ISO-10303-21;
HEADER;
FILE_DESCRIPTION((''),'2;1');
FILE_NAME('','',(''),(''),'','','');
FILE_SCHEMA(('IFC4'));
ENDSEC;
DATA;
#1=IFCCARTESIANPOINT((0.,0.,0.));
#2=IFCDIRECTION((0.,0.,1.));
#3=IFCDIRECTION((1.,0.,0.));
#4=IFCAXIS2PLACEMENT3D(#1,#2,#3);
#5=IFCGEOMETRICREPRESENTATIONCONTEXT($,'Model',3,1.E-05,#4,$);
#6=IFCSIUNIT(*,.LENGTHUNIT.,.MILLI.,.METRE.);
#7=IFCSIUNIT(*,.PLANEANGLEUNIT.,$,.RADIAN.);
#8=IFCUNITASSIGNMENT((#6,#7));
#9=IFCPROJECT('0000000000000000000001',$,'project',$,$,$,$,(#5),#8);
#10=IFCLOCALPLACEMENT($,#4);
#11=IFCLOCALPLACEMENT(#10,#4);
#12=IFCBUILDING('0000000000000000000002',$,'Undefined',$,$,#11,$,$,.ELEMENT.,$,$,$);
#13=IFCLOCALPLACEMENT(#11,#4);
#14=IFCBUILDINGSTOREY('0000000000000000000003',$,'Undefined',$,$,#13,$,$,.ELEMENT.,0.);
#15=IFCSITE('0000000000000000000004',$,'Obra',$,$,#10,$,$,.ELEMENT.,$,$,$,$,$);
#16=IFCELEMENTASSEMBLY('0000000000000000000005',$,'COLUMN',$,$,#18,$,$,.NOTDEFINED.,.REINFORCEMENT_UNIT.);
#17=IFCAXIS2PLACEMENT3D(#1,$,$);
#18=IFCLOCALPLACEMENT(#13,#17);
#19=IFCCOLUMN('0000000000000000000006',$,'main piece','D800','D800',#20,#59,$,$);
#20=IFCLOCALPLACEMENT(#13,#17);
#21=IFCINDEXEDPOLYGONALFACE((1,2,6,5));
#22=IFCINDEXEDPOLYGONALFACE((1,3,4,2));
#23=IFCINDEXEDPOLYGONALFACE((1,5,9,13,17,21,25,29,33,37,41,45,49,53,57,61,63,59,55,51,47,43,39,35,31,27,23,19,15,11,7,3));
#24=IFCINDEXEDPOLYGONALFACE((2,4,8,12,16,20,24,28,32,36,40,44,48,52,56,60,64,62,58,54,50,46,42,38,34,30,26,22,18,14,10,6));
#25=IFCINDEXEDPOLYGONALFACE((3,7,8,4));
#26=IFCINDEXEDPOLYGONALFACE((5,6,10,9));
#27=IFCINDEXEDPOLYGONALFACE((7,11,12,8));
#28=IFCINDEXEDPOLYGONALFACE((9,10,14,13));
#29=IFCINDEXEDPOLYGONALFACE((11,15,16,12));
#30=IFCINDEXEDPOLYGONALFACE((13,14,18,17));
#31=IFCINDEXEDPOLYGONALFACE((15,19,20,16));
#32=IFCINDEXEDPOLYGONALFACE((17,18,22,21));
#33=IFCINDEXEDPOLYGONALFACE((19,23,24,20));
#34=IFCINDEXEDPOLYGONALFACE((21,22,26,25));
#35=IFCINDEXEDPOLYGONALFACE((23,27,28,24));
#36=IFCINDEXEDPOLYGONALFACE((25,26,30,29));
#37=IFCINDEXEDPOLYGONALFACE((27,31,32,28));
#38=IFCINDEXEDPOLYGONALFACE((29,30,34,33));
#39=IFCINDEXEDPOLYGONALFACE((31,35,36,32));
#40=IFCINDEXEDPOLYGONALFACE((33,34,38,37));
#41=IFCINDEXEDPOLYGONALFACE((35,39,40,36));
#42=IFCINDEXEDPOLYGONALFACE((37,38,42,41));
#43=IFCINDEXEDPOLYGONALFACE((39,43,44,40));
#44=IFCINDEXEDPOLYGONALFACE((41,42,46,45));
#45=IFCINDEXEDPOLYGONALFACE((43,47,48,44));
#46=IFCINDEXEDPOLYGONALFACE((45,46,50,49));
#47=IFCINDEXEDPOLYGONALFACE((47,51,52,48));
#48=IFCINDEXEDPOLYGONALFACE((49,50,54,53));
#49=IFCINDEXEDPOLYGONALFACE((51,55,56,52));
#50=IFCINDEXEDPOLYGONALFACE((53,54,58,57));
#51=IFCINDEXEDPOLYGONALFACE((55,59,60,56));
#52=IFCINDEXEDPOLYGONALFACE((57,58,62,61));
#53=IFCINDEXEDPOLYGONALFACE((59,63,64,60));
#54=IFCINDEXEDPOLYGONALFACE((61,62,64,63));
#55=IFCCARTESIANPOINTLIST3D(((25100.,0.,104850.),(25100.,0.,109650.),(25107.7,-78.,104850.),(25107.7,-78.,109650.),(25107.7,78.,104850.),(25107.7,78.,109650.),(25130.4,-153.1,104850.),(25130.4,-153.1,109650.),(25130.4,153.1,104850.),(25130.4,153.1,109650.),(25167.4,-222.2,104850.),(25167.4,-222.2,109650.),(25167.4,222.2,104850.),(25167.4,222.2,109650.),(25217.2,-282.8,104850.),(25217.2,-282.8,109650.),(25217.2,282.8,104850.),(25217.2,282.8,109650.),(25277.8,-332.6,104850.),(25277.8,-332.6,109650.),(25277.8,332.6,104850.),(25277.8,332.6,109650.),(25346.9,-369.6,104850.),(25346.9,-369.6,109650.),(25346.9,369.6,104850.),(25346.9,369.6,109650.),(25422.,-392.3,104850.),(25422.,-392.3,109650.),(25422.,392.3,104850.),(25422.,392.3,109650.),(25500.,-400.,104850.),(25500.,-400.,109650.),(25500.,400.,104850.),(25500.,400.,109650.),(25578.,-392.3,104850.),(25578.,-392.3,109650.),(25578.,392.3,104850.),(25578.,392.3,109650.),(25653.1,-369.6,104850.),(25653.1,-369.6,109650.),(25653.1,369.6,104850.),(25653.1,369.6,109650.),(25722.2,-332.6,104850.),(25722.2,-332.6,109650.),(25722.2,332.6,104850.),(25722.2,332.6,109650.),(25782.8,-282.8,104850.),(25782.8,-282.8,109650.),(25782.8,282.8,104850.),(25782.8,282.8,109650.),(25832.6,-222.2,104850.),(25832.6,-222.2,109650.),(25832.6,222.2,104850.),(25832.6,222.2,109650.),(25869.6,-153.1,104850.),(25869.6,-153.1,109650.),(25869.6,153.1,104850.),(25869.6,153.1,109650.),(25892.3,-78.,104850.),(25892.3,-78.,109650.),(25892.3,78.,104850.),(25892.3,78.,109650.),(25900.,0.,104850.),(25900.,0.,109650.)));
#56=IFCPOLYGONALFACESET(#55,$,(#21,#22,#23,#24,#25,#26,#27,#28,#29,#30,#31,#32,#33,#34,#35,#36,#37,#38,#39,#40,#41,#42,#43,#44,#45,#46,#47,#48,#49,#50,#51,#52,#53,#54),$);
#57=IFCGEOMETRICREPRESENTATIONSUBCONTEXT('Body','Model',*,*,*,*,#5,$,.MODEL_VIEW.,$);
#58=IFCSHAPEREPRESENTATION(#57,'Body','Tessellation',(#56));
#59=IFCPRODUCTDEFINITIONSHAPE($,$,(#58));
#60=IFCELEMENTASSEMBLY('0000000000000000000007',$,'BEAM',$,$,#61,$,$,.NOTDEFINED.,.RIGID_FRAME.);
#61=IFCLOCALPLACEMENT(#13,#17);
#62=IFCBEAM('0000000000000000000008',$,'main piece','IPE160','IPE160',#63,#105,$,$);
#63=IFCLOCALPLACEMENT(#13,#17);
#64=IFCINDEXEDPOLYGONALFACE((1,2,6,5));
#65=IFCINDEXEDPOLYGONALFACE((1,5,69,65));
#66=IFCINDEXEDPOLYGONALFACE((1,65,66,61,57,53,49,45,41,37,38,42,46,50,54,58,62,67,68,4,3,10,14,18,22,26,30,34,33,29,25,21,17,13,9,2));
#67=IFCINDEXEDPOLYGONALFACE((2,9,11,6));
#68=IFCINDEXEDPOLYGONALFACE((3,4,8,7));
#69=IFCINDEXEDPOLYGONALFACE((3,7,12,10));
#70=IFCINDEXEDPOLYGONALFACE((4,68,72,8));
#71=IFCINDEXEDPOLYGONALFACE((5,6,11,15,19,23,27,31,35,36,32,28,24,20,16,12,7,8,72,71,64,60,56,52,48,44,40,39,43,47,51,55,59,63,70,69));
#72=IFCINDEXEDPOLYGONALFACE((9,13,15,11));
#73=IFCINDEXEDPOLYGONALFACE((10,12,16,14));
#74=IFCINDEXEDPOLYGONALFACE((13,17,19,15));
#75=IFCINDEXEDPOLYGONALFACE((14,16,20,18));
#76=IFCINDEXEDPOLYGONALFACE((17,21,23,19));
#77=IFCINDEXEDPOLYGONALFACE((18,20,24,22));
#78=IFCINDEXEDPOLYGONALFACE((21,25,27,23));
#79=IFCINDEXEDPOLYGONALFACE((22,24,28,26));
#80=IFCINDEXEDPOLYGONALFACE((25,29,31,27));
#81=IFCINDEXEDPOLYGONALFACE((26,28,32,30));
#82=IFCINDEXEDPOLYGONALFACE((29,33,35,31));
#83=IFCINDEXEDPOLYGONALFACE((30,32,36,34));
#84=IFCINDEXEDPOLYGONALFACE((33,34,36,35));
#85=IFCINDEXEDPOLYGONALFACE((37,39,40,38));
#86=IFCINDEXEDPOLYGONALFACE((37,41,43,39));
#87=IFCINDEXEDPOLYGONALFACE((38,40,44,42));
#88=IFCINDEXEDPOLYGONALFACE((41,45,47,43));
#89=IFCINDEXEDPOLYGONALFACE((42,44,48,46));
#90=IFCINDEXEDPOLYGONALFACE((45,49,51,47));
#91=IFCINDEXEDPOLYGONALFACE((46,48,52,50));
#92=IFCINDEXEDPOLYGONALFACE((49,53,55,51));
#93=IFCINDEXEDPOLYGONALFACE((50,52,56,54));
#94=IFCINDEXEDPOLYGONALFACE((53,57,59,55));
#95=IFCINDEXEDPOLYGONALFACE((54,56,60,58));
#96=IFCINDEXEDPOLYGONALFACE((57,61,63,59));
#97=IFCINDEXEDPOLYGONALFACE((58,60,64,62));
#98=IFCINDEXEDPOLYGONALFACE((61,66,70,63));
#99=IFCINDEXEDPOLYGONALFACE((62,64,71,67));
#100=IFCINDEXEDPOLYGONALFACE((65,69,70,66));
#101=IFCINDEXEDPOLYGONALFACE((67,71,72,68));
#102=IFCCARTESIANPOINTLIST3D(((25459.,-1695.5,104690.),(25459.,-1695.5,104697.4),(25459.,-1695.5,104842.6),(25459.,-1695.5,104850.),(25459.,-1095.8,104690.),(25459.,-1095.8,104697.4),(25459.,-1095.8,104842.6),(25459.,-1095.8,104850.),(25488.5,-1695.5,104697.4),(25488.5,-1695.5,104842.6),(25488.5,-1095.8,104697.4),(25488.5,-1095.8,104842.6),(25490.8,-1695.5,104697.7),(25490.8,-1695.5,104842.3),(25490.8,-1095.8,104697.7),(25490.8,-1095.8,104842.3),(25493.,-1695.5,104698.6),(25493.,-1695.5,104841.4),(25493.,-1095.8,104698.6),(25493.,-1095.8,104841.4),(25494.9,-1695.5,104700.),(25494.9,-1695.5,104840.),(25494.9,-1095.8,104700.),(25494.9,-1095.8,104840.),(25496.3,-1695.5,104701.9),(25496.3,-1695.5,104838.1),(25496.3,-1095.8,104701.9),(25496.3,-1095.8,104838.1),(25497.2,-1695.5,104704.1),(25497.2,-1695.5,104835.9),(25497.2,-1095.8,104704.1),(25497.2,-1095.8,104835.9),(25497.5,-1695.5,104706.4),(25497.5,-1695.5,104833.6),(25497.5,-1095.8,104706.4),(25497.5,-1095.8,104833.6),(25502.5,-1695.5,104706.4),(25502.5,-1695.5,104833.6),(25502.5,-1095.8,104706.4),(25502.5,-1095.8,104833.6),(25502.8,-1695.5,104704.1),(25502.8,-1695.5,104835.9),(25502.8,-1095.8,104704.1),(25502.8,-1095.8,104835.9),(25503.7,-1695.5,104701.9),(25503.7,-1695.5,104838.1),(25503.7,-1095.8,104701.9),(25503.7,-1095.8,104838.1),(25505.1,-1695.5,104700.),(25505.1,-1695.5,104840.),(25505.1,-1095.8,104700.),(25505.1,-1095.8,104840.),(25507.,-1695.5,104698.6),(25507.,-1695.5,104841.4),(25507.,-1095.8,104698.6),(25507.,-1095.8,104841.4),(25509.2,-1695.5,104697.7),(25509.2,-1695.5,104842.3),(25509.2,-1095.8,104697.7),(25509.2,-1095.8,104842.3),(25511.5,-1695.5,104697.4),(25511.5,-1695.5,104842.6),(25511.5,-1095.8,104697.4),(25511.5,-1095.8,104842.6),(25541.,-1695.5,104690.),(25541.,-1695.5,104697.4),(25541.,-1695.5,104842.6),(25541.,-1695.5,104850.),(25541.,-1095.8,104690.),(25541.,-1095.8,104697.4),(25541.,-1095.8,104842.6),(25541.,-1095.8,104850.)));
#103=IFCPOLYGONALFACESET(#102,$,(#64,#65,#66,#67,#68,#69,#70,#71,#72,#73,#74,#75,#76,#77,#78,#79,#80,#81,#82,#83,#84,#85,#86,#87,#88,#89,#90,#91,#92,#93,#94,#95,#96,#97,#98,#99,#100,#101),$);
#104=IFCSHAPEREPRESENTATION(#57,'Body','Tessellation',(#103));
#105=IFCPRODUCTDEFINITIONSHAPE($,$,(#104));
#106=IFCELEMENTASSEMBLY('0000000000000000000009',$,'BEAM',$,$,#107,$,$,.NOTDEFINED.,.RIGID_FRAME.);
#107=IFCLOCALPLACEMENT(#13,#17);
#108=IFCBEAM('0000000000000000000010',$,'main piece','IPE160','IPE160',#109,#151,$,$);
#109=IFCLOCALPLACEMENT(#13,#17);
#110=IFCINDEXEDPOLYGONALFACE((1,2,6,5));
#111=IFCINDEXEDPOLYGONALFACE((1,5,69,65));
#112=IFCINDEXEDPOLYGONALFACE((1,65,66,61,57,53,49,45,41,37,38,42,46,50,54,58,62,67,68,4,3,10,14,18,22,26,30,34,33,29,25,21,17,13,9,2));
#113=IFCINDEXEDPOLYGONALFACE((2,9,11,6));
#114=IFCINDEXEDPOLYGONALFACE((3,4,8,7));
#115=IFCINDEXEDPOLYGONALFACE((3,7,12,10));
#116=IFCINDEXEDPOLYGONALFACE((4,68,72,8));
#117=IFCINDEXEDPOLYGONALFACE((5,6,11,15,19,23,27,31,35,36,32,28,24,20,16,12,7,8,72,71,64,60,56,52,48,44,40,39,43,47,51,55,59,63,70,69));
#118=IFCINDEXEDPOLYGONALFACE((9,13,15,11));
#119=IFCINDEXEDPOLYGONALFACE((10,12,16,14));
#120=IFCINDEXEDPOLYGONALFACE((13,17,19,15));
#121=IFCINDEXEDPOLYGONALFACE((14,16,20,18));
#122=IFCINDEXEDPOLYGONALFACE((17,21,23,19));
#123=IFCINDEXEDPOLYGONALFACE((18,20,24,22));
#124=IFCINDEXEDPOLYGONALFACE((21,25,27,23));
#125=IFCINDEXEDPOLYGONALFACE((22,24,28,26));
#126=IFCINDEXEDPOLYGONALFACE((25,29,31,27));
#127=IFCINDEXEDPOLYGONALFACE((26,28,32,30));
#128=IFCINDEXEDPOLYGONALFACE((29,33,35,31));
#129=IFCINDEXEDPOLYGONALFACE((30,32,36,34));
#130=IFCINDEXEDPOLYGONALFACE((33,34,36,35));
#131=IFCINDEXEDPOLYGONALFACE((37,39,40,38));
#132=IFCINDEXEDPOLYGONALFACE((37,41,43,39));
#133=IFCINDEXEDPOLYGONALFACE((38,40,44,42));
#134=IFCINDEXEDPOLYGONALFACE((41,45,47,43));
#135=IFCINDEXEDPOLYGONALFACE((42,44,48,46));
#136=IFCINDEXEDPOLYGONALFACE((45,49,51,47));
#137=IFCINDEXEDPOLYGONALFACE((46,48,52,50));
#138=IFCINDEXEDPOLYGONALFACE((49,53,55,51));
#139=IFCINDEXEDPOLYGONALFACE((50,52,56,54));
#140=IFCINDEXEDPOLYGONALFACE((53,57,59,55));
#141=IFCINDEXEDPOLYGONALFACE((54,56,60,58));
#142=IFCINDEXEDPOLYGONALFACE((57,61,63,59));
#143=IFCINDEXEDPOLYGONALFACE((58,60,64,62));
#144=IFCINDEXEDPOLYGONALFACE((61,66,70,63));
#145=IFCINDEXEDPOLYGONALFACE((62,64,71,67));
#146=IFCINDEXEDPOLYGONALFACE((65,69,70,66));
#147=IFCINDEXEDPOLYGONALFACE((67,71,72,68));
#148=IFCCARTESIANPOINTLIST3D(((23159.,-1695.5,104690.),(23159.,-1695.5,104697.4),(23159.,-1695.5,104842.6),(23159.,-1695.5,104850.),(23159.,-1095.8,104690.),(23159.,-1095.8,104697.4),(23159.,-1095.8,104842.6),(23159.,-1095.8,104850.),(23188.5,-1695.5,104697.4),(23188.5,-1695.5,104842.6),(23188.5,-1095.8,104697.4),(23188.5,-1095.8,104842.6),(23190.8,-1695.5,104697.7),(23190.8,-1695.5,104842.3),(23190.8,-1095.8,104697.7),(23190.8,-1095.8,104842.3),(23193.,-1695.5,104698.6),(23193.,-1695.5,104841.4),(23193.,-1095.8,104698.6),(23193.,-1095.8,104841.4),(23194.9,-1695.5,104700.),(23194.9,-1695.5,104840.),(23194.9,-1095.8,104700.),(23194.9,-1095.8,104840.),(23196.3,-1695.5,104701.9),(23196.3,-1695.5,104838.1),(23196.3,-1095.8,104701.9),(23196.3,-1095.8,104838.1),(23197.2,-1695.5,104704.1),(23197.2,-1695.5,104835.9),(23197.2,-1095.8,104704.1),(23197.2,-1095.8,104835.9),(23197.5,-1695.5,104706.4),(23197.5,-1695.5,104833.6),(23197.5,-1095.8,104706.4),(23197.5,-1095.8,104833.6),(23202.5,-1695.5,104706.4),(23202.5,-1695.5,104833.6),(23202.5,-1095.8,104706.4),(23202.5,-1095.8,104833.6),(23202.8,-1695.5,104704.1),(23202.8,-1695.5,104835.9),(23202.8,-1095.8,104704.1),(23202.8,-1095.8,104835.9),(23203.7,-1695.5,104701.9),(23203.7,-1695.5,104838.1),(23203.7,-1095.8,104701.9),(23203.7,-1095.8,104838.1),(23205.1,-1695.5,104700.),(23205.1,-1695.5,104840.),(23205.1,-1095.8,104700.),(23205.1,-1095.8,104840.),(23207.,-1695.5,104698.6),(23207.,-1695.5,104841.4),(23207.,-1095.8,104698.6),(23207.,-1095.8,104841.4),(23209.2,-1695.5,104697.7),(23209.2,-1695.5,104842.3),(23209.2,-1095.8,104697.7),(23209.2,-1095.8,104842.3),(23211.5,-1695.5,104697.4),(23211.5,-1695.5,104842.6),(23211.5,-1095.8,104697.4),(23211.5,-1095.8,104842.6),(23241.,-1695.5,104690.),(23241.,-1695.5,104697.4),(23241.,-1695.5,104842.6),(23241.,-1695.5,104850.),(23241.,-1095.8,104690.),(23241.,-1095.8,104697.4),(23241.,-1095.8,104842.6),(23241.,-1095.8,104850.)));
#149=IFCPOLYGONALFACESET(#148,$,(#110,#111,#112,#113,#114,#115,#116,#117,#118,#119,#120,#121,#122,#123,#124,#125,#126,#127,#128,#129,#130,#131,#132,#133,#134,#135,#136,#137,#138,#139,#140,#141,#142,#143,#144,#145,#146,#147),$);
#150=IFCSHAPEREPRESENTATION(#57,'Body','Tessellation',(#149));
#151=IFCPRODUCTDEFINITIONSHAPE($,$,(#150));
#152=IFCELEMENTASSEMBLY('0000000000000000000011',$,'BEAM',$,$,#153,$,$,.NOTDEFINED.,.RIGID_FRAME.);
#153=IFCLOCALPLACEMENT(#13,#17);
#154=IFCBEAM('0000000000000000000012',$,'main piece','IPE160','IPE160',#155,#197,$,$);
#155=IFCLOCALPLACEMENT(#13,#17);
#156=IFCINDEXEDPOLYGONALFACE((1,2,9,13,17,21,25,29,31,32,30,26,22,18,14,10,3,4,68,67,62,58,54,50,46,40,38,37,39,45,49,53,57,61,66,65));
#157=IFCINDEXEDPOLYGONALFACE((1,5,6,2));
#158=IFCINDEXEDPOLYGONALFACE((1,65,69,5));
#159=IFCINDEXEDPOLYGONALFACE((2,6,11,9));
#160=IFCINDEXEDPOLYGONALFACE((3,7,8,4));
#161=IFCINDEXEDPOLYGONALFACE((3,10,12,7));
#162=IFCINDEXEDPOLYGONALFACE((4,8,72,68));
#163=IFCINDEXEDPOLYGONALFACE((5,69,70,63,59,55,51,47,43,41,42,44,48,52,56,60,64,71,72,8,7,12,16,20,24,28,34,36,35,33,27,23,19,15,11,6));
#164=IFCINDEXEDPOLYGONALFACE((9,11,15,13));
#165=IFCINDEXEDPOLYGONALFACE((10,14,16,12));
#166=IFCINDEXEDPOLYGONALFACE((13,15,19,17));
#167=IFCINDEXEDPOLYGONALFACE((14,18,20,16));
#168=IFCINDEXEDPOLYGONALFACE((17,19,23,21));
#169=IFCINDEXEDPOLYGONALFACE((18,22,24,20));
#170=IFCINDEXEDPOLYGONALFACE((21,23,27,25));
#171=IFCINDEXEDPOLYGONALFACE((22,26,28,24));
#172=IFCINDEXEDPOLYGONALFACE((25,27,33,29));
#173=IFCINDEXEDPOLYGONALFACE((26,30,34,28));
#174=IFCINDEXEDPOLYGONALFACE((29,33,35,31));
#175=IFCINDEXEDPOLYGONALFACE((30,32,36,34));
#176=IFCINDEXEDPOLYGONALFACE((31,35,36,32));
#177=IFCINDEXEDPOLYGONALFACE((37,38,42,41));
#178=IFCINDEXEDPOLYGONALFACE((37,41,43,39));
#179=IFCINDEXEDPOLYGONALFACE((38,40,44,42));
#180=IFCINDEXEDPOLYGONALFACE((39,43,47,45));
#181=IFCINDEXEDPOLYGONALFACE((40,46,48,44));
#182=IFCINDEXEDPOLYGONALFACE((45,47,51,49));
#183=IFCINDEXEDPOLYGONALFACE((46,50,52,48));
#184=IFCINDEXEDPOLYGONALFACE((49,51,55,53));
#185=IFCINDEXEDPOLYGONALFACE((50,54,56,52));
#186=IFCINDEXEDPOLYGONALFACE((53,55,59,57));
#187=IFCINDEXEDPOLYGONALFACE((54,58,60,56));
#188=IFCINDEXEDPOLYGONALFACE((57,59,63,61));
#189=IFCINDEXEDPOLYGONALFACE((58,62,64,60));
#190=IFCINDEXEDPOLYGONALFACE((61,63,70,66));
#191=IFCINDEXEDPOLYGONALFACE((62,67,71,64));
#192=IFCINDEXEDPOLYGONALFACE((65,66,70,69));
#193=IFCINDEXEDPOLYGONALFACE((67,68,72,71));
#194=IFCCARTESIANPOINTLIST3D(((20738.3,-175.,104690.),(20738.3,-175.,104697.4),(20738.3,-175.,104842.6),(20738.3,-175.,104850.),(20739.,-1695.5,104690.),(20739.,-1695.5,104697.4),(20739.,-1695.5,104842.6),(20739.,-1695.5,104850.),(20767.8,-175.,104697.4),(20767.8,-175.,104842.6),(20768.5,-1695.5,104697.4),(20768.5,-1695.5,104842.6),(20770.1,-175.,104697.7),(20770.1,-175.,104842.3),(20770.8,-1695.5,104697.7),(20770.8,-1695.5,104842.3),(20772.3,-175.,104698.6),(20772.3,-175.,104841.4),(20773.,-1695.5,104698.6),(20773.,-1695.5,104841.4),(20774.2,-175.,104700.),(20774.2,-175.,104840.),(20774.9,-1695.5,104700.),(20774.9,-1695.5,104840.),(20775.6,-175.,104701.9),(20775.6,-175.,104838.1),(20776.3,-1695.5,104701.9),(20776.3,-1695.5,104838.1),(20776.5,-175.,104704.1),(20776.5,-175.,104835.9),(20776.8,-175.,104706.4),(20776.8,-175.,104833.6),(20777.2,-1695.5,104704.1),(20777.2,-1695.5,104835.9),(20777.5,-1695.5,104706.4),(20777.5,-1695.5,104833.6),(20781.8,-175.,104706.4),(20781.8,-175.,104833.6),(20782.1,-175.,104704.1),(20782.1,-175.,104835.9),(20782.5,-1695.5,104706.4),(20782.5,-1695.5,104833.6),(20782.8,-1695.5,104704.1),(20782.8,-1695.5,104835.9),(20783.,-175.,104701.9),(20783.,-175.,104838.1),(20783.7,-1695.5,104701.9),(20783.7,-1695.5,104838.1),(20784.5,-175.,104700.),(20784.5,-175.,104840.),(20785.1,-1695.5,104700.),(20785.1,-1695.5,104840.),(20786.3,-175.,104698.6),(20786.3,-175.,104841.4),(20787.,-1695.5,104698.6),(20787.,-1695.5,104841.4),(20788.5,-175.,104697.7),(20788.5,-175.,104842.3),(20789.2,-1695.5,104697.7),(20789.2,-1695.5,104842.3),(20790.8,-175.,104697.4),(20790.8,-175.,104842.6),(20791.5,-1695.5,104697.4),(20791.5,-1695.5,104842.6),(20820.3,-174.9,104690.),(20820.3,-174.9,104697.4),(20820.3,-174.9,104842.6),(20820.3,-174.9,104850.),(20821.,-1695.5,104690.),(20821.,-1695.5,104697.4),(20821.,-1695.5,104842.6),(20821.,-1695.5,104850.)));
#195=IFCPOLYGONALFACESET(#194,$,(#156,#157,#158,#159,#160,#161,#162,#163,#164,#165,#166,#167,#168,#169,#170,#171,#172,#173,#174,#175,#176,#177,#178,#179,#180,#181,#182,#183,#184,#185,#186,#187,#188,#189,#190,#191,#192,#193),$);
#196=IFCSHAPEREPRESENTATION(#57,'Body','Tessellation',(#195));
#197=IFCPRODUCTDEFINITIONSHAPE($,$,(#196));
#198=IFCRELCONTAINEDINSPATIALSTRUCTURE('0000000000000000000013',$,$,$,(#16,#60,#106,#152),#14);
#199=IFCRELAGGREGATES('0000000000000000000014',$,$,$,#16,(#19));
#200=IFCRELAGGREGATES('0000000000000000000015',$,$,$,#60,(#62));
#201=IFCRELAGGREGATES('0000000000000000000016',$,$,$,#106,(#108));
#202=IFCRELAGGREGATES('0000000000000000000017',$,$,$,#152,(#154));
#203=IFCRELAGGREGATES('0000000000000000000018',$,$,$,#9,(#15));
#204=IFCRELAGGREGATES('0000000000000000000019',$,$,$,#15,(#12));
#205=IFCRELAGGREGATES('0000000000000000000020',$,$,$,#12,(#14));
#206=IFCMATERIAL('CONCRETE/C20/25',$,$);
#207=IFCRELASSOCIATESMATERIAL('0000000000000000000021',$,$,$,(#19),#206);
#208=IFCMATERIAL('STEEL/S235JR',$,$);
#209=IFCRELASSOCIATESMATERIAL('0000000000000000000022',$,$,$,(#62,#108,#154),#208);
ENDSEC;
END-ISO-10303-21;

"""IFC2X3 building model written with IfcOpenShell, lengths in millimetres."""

from ifc_helpers import new_model, si_unit, frame, origin_with_axes, origin_2d_with_axis, place, context, subcontext, project, spatial, circle, i_section, extrude, material, element, aggregate, save


model = new_model("IFC2X3")

# Units and contexts
model_context = context("Model", 3, precision=1e-05, world=origin_with_axes())
body_context = subcontext(model_context, "Body", "Model", "MODEL_VIEW")
ifc_project = project(units=[si_unit("LENGTHUNIT", "METRE", prefix="MILLI"), si_unit("PLANEANGLEUNIT", "RADIAN")], contexts=[model_context])

# Site, building, storey
site_placement = place(None, origin_with_axes())
site = spatial("IfcSite", under=ifc_project, at=site_placement, Name="Obra", CompositionType="ELEMENT")
building_placement = place(site_placement, origin_with_axes())
building = spatial("IfcBuilding", under=site, at=building_placement, Name="Undefined", CompositionType="ELEMENT")
storey_placement = place(building_placement, origin_with_axes())
storey = spatial("IfcBuildingStorey", under=building, at=storey_placement, Name="Undefined", CompositionType="ELEMENT", Elevation=0.0)

# Element assembly, column
assembly_1_placement = place(storey_placement, origin_with_axes())
assembly_1 = element("IfcElementAssembly", 1, at=assembly_1_placement, inside=storey, Name="COLUMN", AssemblyPlace="NOTDEFINED", PredefinedType="REINFORCEMENT_UNIT")
ifc_material_1 = material(Name="CONCRETE/C20/25")
column_placement = place(assembly_1_placement, frame((25500.0, 0.0, 104850.0), z_axis=(0.0, 0.0, 1.0), x_axis=(0.0, 1.0, 0.0)))
column = element("IfcColumn", 2, at=column_placement, material=ifc_material_1, Name="main piece", Description="D800", ObjectType="D800", context=body_context, shape_type="SweptSolid", body=[
    extrude(circle(Radius=400.0, at=origin_2d_with_axis()), frame((0.0, 0.0, 4800.0), z_axis=(0.0, 0.0, -1.0), x_axis=(0.0, 1.0, 0.0)), (0.0, 0.0, 1.0), 4800.0),
])
aggregate(assembly_1, [column])

# Element assemblies, beams
assembly_2_placement = place(storey_placement, origin_with_axes())
assembly_2 = element("IfcElementAssembly", 3, at=assembly_2_placement, inside=storey, Name="BEAM", AssemblyPlace="NOTDEFINED", PredefinedType="RIGID_FRAME")
ifc_material_2 = material(Name="STEEL/S235JR")
beam_1_placement = place(assembly_2_placement, frame((25500.0, -1095.8, 104770.0), z_axis=(0.0, 0.0, 1.0), x_axis=(0.0, -1.0, 0.0)))
beam_1 = element("IfcBeam", 4, at=beam_1_placement, material=ifc_material_2, Name="main piece", Description="IPE160", ObjectType="IPE160", context=body_context, shape_type="SweptSolid", body=[
    extrude(i_section(OverallWidth=82.0, OverallDepth=160.0, WebThickness=5.0, FlangeThickness=7.4, FilletRadius=9.0, at=origin_2d_with_axis()), frame((599.7, 0.0, 0.0), z_axis=(-1.0, 0.0, 0.0), x_axis=(0.0, -1.0, 0.0)), (0.0, 0.0, 1.0), 599.7),
])
aggregate(assembly_2, [beam_1])
assembly_3_placement = place(storey_placement, origin_with_axes())
assembly_3 = element("IfcElementAssembly", 5, at=assembly_3_placement, inside=storey, Name="BEAM", AssemblyPlace="NOTDEFINED", PredefinedType="RIGID_FRAME")
beam_2_placement = place(assembly_3_placement, frame((23200.0, -1695.5, 104770.0), z_axis=(0.0, 0.0, 1.0), x_axis=(0.0, 1.0, 0.0)))
beam_2 = element("IfcBeam", 6, at=beam_2_placement, material=ifc_material_2, Name="main piece", Description="IPE160", ObjectType="IPE160", context=body_context, shape_type="SweptSolid", body=[
    extrude(i_section(OverallWidth=82.0, OverallDepth=160.0, WebThickness=5.0, FlangeThickness=7.4, FilletRadius=9.0, at=origin_2d_with_axis()), frame((599.7, 0.0, 0.0), z_axis=(-1.0, 0.0, 0.0), x_axis=(0.0, -1.0, 0.0)), (0.0, 0.0, 1.0), 599.7),
])
aggregate(assembly_3, [beam_2])
assembly_4_placement = place(storey_placement, origin_with_axes())
assembly_4 = element("IfcElementAssembly", 7, at=assembly_4_placement, inside=storey, Name="BEAM", AssemblyPlace="NOTDEFINED", PredefinedType="RIGID_FRAME")
beam_3_placement = place(assembly_4_placement, frame((20779.3, -175.0, 104770.0), z_axis=(0.0, 0.0, 1.0), x_axis=(0.00045, -1.0, 0.0)))
beam_3 = element("IfcBeam", 8, at=beam_3_placement, material=ifc_material_2, Name="main piece", Description="IPE160", ObjectType="IPE160", context=body_context, shape_type="SweptSolid", body=[
    extrude(i_section(OverallWidth=82.0, OverallDepth=160.0, WebThickness=5.0, FlangeThickness=7.4, FilletRadius=9.0, at=origin_2d_with_axis()), frame((1520.5, 0.0, 0.0), z_axis=(-1.0, 0.0, 0.0), x_axis=(0.0, -1.0, 0.0)), (0.0, 0.0, 1.0), 1520.5),
])
aggregate(assembly_4, [beam_3])

save(model, "model.ifc")
